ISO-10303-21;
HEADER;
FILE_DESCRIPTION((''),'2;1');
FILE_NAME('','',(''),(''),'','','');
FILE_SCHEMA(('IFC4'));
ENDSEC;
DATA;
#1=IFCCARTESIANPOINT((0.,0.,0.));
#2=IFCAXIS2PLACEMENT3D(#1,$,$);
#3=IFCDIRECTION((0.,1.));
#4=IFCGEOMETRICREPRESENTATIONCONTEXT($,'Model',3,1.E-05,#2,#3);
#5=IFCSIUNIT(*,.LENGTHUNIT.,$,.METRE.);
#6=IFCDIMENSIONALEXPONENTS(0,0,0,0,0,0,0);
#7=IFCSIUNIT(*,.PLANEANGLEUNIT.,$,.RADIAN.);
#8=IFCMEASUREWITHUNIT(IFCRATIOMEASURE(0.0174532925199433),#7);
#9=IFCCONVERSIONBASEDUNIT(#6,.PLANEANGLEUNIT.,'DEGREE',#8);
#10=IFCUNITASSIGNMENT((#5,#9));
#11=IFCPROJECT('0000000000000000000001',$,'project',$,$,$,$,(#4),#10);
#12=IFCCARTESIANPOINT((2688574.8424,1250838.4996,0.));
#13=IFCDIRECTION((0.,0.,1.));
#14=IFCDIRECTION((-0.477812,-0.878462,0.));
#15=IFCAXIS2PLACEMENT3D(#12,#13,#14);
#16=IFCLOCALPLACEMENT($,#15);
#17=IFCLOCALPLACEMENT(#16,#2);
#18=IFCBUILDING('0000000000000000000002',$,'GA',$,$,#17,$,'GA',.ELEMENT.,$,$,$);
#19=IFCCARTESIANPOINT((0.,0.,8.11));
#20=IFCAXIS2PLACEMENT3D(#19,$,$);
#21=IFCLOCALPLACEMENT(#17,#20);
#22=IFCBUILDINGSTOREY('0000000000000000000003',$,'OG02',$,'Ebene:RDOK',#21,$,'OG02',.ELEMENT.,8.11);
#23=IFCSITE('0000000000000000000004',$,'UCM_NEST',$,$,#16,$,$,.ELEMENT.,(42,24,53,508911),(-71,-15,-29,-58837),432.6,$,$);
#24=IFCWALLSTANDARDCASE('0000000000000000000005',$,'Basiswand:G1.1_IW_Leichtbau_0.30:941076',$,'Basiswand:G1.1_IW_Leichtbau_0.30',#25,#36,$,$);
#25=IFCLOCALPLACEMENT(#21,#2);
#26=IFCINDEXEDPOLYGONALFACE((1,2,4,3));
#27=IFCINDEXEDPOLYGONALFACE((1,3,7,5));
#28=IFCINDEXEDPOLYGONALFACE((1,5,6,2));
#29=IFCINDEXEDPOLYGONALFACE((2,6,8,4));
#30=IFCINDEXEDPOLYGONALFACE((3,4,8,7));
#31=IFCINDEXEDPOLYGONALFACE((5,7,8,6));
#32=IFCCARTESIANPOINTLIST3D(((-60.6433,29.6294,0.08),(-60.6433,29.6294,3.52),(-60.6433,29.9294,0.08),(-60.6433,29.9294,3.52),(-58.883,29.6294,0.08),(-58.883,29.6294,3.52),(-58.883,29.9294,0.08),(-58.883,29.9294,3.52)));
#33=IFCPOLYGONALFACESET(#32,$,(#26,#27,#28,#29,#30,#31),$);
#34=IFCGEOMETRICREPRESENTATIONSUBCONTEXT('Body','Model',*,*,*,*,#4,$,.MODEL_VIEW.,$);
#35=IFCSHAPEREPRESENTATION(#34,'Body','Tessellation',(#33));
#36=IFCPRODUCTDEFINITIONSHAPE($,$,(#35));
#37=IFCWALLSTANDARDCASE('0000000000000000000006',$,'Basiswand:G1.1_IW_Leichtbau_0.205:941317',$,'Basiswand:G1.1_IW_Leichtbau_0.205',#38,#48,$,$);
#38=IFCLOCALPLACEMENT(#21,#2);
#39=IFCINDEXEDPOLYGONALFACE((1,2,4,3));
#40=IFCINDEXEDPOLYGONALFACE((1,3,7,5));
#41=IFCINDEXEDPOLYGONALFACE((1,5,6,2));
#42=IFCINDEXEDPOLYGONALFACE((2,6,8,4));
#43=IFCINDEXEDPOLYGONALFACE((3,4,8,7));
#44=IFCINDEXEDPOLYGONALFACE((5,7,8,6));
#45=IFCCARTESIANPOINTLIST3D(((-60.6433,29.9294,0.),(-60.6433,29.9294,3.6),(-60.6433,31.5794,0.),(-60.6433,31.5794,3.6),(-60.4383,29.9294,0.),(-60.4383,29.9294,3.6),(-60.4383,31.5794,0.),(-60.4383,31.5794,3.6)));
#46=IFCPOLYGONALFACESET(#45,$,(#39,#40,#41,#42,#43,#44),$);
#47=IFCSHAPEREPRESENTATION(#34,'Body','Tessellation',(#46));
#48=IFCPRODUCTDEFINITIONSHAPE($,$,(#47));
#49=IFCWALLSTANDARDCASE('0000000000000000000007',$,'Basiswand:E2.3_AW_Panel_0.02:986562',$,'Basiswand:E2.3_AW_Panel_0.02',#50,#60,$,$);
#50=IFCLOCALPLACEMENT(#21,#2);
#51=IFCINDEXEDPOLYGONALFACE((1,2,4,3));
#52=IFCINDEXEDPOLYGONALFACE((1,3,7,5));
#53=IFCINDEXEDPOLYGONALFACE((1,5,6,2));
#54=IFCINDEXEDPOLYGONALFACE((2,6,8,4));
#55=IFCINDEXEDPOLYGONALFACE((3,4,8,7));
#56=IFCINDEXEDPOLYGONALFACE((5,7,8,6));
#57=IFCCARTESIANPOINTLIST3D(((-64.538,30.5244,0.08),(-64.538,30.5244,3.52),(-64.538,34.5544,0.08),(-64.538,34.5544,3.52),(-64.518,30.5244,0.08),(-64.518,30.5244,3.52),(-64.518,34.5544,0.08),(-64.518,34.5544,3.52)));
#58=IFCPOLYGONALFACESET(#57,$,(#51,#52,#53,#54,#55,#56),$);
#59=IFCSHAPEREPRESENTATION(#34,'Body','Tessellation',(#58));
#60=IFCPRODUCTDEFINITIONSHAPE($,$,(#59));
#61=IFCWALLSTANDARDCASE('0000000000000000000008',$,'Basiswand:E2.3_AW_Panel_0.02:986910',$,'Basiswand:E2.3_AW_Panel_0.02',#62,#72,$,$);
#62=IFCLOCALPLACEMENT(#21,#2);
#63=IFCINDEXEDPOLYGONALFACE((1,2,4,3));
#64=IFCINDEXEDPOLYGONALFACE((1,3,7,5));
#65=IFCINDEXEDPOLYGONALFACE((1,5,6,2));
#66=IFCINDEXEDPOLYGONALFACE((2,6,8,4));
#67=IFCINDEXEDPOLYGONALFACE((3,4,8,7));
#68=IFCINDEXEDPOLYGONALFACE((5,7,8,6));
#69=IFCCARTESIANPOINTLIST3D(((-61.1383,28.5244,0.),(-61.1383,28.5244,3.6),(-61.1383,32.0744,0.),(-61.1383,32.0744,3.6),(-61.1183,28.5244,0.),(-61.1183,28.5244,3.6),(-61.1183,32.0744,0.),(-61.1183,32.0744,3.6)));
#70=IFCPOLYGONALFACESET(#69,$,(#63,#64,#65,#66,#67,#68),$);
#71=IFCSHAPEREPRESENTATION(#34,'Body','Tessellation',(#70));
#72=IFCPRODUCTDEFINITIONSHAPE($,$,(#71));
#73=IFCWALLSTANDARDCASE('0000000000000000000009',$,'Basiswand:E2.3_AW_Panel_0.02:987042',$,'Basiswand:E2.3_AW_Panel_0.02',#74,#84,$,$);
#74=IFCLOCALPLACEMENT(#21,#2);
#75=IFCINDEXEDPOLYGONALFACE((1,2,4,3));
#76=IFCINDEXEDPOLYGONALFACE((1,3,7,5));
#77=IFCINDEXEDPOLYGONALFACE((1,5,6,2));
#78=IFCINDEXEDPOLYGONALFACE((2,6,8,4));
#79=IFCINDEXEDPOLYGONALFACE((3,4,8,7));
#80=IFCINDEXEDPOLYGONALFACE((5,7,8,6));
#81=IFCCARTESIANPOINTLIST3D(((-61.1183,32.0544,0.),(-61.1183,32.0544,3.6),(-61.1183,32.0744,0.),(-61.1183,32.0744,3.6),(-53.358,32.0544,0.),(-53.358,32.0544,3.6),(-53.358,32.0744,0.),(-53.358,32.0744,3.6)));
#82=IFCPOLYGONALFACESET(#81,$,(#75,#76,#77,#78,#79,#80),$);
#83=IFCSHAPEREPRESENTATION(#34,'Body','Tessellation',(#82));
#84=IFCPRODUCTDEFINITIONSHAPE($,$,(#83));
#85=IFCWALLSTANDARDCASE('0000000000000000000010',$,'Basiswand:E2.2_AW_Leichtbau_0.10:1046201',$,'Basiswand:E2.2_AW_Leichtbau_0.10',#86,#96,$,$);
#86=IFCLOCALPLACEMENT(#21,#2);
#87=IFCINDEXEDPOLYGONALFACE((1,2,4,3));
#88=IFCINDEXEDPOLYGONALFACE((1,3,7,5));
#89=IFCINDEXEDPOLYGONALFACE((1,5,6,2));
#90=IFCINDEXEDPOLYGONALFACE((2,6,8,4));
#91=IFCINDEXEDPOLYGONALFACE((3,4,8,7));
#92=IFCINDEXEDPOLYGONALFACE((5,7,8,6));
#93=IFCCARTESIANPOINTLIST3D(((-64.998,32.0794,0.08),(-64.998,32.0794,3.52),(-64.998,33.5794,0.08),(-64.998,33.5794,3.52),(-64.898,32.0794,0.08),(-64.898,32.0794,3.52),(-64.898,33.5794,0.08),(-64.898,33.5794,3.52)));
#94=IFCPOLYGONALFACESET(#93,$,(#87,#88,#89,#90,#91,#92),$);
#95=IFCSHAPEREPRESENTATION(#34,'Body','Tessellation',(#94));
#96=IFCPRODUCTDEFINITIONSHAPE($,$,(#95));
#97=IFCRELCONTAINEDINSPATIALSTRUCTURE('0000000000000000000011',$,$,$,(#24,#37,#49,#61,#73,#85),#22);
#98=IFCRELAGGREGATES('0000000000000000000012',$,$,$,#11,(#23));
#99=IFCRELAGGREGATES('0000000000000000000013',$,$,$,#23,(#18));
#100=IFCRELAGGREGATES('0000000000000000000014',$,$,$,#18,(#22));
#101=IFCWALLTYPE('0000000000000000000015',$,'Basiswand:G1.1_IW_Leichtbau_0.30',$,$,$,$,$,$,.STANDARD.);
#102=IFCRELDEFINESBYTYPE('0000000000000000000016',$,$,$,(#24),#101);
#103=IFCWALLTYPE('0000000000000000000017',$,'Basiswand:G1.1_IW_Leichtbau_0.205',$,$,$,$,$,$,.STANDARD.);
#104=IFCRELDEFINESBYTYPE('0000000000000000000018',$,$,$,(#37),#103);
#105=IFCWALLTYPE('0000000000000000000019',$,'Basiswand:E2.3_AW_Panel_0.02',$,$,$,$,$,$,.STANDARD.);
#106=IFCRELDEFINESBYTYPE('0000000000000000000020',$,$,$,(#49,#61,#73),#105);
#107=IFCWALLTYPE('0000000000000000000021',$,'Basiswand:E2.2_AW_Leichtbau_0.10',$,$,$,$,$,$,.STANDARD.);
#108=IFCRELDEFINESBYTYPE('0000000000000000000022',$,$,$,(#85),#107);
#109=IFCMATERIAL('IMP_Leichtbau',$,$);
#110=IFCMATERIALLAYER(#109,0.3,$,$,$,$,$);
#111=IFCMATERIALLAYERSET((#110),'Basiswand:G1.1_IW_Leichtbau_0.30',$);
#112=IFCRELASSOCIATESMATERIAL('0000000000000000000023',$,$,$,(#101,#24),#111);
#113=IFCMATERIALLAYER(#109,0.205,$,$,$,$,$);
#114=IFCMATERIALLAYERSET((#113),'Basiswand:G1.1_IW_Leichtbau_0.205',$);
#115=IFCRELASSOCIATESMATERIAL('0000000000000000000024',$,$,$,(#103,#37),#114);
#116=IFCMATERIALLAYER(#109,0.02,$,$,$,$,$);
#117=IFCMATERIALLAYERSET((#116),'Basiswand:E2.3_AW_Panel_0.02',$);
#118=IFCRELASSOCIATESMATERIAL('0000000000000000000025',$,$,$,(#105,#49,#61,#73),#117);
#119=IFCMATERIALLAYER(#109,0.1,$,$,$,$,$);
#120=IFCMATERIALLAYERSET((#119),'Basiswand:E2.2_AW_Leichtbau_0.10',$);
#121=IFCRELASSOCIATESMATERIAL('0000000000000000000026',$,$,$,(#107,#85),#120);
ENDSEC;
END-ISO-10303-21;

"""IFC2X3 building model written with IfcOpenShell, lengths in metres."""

from ifc_helpers import new_model, entity, si_unit, converted_unit, direction, frame, frame_2d, origin, place, context, subcontext, project, spatial, polyline, rectangle, extrude, clip, bounded_halfspace, material, layer, layer_set, layer_usage, type_object, element, save


model = new_model("IFC2X3")

# Units and contexts
model_context = context("Model", 3, precision=1e-05, world=origin(), true_north=direction((0.0, 1.0)))
body_context = subcontext(model_context, "Body", "Model", "MODEL_VIEW")
ifc_project = project(units=[si_unit("LENGTHUNIT", "METRE"), converted_unit("PLANEANGLEUNIT", "DEGREE", entity("IfcRatioMeasure", 0.0174532925199433), si_unit("PLANEANGLEUNIT", "RADIAN"), dimensions=[0, 0, 0, 0, 0, 0, 0])], contexts=[model_context])

# Site, building, storey
site_placement = place(None, frame((2688574.8424, 1250838.4996, 0.0), z_axis=(0.0, 0.0, 1.0), x_axis=(-0.477812, -0.878462, 0.0)))
site = spatial("IfcSite", under=ifc_project, at=site_placement, Name="UCM_NEST", CompositionType="ELEMENT", RefLatitude=(42, 24, 53, 508911), RefLongitude=(-71, -15, -29, -58837), RefElevation=432.6)
building_placement = place(site_placement, origin())
building = spatial("IfcBuilding", under=site, at=building_placement, Name="GA", LongName="GA", CompositionType="ELEMENT")
storey_placement = place(building_placement, frame((0.0, 0.0, 8.11)))
storey = spatial("IfcBuildingStorey", under=building, at=storey_placement, Name="OG02", ObjectType="Ebene:RDOK", LongName="OG02", CompositionType="ELEMENT", Elevation=8.11)

# Walls
ifc_material_1 = material(Name="IMP_Leichtbau")
ifc_layer_1 = layer(ifc_material_1, 0.3)
ifc_layer_set_1 = layer_set([ifc_layer_1], Name="Basiswand:G1.1_IW_Leichtbau_0.30")
ifc_layer_usage_1 = layer_usage(ifc_layer_set_1, "AXIS2", "NEGATIVE", 0.15)
wall_type_1 = type_object("IfcWallType", Name="Basiswand:G1.1_IW_Leichtbau_0.30", PredefinedType="STANDARD", material=ifc_layer_set_1)
wall_1_placement = place(storey_placement, frame((-60.6433, 29.7794, 0.08)))
element("IfcWallStandardCase", 1, at=wall_1_placement, inside=storey, type_object=wall_type_1, material=ifc_layer_usage_1, Name="Basiswand:G1.1_IW_Leichtbau_0.30:941076", ObjectType="Basiswand:G1.1_IW_Leichtbau_0.30", context=body_context, shape_type="Clipping", body=[
    clip(clip(extrude(rectangle(XDim=1.7603, YDim=0.3, at=frame_2d((0.8801, 0.0), x_axis=(-1.0, 0.0))), origin(), (0.0, 0.0, 1.0), 3.44), bounded_halfspace(frame((1.7603, -0.15, 0.0), z_axis=(0.0, 0.0, 1.0), x_axis=(-1.0, 0.0, 0.0)), True, frame((1.7603, -0.15, 0.0), z_axis=(0.0, 0.0, 1.0), x_axis=(-1.0, 0.0, 0.0)), polyline([(0.0, 0.0), (0.0, -0.3), (1.7603, -0.3), (1.7603, 0.0), (0.0, 0.0)]))), bounded_halfspace(frame((0.0, -0.15, 3.44), z_axis=(0.0, 0.0, -1.0), x_axis=(-1.0, 0.0, 0.0)), True, frame((0.0, -0.15, 3.44), z_axis=(0.0, 0.0, -1.0), x_axis=(-1.0, 0.0, 0.0)), polyline([(0.0, 0.0), (0.0, 0.3), (-1.7603, 0.3), (-1.7603, 0.0), (0.0, 0.0)]))),
])
ifc_layer_2 = layer(ifc_material_1, 0.205)
ifc_layer_set_2 = layer_set([ifc_layer_2], Name="Basiswand:G1.1_IW_Leichtbau_0.205")
ifc_layer_usage_2 = layer_usage(ifc_layer_set_2, "AXIS2", "NEGATIVE", 0.1025)
wall_type_2 = type_object("IfcWallType", Name="Basiswand:G1.1_IW_Leichtbau_0.205", PredefinedType="STANDARD", material=ifc_layer_set_2)
wall_2_placement = place(storey_placement, frame((-60.5408, 31.5794, 0.0), z_axis=(0.0, 0.0, 1.0), x_axis=(0.0, -1.0, 0.0)))
element("IfcWallStandardCase", 2, at=wall_2_placement, inside=storey, type_object=wall_type_2, material=ifc_layer_usage_2, Name="Basiswand:G1.1_IW_Leichtbau_0.205:941317", ObjectType="Basiswand:G1.1_IW_Leichtbau_0.205", context=body_context, shape_type="SweptSolid", body=[
    extrude(rectangle(XDim=1.65, YDim=0.205, at=frame_2d((0.825, 0.0), x_axis=(-1.0, 0.0))), origin(), (0.0, 0.0, 1.0), 3.6),
])
ifc_layer_3 = layer(ifc_material_1, 0.02)
ifc_layer_set_3 = layer_set([ifc_layer_3], Name="Basiswand:E2.3_AW_Panel_0.02")
ifc_layer_usage_3 = layer_usage(ifc_layer_set_3, "AXIS2", "NEGATIVE", 0.01)
wall_type_3 = type_object("IfcWallType", Name="Basiswand:E2.3_AW_Panel_0.02", PredefinedType="STANDARD", material=ifc_layer_set_3)
wall_3_placement = place(storey_placement, frame((-64.528, 34.5544, 0.08), z_axis=(0.0, 0.0, 1.0), x_axis=(0.0, -1.0, 0.0)))
element("IfcWallStandardCase", 3, at=wall_3_placement, inside=storey, type_object=wall_type_3, material=ifc_layer_usage_3, Name="Basiswand:E2.3_AW_Panel_0.02:986562", ObjectType="Basiswand:E2.3_AW_Panel_0.02", context=body_context, shape_type="Clipping", body=[
    clip(clip(extrude(rectangle(XDim=4.03, YDim=0.02, at=frame_2d((2.015, 0.0), x_axis=(-1.0, 0.0))), origin(), (0.0, 0.0, 1.0), 3.44), bounded_halfspace(frame((4.03, -0.01, 0.0), z_axis=(0.0, 0.0, 1.0), x_axis=(0.0, -1.0, 0.0)), True, frame((4.03, -0.01, 0.0), z_axis=(0.0, 0.0, 1.0), x_axis=(0.0, -1.0, 0.0)), polyline([(0.0, 0.0), (-0.02, 0.0), (-0.02, -4.03), (0.0, -4.03), (0.0, 0.0)]))), bounded_halfspace(frame((0.0, -0.01, 3.44), z_axis=(0.0, 0.0, -1.0), x_axis=(0.0, -1.0, 0.0)), True, frame((0.0, -0.01, 3.44), z_axis=(0.0, 0.0, -1.0), x_axis=(0.0, -1.0, 0.0)), polyline([(0.0, 0.0), (-0.02, 0.0), (-0.02, -4.03), (0.0, -4.03), (0.0, 0.0)]))),
])
ifc_layer_usage_4 = layer_usage(ifc_layer_set_3, "AXIS2", "NEGATIVE", 0.01)
wall_4_placement = place(storey_placement, frame((-61.1283, 28.5244, 0.0), z_axis=(0.0, 0.0, 1.0), x_axis=(0.0, 1.0, 0.0)))
element("IfcWallStandardCase", 4, at=wall_4_placement, inside=storey, type_object=wall_type_3, material=ifc_layer_usage_4, Name="Basiswand:E2.3_AW_Panel_0.02:986910", ObjectType="Basiswand:E2.3_AW_Panel_0.02", context=body_context, shape_type="SweptSolid", body=[
    extrude(rectangle(XDim=3.55, YDim=0.02, at=frame_2d((1.775, 0.0), x_axis=(-1.0, 0.0))), origin(), (0.0, 0.0, 1.0), 3.6),
])
ifc_layer_usage_5 = layer_usage(ifc_layer_set_3, "AXIS2", "NEGATIVE", 0.01)
wall_5_placement = place(storey_placement, frame((-61.1183, 32.0644, 0.0)))
element("IfcWallStandardCase", 5, at=wall_5_placement, inside=storey, type_object=wall_type_3, material=ifc_layer_usage_5, Name="Basiswand:E2.3_AW_Panel_0.02:987042", ObjectType="Basiswand:E2.3_AW_Panel_0.02", context=body_context, shape_type="SweptSolid", body=[
    extrude(rectangle(XDim=7.7603, YDim=0.02, at=frame_2d((3.8801, 0.0), x_axis=(-1.0, 0.0))), origin(), (0.0, 0.0, 1.0), 3.6),
])

# Wall
ifc_layer_4 = layer(ifc_material_1, 0.1)
ifc_layer_set_4 = layer_set([ifc_layer_4], Name="Basiswand:E2.2_AW_Leichtbau_0.10")
ifc_layer_usage_6 = layer_usage(ifc_layer_set_4, "AXIS2", "NEGATIVE", 0.05)
wall_type_4 = type_object("IfcWallType", Name="Basiswand:E2.2_AW_Leichtbau_0.10", PredefinedType="STANDARD", material=ifc_layer_set_4)
wall_6_placement = place(storey_placement, frame((-64.948, 33.5794, 0.08), z_axis=(0.0, 0.0, 1.0), x_axis=(0.0, -1.0, 0.0)))
element("IfcWallStandardCase", 6, at=wall_6_placement, inside=storey, type_object=wall_type_4, material=ifc_layer_usage_6, Name="Basiswand:E2.2_AW_Leichtbau_0.10:1046201", ObjectType="Basiswand:E2.2_AW_Leichtbau_0.10", context=body_context, shape_type="Clipping", body=[
    clip(clip(extrude(rectangle(XDim=1.5, YDim=0.1, at=frame_2d((0.75, 0.0), x_axis=(-1.0, 0.0))), origin(), (0.0, 0.0, 1.0), 3.44), bounded_halfspace(frame((1.5, -0.05, 0.0), z_axis=(0.0, 0.0, 1.0), x_axis=(0.0, -1.0, 0.0)), True, frame((1.5, -0.05, 0.0), z_axis=(0.0, 0.0, 1.0), x_axis=(0.0, -1.0, 0.0)), polyline([(0.0, 0.0), (-0.1, 0.0), (-0.1, -1.5), (0.0, -1.5), (0.0, 0.0)]))), bounded_halfspace(frame((0.0, -0.05, 3.44), z_axis=(0.0, 0.0, -1.0), x_axis=(0.0, -1.0, 0.0)), True, frame((0.0, -0.05, 3.44), z_axis=(0.0, 0.0, -1.0), x_axis=(0.0, -1.0, 0.0)), polyline([(0.0, 0.0), (-0.1, 0.0), (-0.1, -1.5), (0.0, -1.5), (0.0, 0.0)]))),
])

save(model, "model.ifc")
